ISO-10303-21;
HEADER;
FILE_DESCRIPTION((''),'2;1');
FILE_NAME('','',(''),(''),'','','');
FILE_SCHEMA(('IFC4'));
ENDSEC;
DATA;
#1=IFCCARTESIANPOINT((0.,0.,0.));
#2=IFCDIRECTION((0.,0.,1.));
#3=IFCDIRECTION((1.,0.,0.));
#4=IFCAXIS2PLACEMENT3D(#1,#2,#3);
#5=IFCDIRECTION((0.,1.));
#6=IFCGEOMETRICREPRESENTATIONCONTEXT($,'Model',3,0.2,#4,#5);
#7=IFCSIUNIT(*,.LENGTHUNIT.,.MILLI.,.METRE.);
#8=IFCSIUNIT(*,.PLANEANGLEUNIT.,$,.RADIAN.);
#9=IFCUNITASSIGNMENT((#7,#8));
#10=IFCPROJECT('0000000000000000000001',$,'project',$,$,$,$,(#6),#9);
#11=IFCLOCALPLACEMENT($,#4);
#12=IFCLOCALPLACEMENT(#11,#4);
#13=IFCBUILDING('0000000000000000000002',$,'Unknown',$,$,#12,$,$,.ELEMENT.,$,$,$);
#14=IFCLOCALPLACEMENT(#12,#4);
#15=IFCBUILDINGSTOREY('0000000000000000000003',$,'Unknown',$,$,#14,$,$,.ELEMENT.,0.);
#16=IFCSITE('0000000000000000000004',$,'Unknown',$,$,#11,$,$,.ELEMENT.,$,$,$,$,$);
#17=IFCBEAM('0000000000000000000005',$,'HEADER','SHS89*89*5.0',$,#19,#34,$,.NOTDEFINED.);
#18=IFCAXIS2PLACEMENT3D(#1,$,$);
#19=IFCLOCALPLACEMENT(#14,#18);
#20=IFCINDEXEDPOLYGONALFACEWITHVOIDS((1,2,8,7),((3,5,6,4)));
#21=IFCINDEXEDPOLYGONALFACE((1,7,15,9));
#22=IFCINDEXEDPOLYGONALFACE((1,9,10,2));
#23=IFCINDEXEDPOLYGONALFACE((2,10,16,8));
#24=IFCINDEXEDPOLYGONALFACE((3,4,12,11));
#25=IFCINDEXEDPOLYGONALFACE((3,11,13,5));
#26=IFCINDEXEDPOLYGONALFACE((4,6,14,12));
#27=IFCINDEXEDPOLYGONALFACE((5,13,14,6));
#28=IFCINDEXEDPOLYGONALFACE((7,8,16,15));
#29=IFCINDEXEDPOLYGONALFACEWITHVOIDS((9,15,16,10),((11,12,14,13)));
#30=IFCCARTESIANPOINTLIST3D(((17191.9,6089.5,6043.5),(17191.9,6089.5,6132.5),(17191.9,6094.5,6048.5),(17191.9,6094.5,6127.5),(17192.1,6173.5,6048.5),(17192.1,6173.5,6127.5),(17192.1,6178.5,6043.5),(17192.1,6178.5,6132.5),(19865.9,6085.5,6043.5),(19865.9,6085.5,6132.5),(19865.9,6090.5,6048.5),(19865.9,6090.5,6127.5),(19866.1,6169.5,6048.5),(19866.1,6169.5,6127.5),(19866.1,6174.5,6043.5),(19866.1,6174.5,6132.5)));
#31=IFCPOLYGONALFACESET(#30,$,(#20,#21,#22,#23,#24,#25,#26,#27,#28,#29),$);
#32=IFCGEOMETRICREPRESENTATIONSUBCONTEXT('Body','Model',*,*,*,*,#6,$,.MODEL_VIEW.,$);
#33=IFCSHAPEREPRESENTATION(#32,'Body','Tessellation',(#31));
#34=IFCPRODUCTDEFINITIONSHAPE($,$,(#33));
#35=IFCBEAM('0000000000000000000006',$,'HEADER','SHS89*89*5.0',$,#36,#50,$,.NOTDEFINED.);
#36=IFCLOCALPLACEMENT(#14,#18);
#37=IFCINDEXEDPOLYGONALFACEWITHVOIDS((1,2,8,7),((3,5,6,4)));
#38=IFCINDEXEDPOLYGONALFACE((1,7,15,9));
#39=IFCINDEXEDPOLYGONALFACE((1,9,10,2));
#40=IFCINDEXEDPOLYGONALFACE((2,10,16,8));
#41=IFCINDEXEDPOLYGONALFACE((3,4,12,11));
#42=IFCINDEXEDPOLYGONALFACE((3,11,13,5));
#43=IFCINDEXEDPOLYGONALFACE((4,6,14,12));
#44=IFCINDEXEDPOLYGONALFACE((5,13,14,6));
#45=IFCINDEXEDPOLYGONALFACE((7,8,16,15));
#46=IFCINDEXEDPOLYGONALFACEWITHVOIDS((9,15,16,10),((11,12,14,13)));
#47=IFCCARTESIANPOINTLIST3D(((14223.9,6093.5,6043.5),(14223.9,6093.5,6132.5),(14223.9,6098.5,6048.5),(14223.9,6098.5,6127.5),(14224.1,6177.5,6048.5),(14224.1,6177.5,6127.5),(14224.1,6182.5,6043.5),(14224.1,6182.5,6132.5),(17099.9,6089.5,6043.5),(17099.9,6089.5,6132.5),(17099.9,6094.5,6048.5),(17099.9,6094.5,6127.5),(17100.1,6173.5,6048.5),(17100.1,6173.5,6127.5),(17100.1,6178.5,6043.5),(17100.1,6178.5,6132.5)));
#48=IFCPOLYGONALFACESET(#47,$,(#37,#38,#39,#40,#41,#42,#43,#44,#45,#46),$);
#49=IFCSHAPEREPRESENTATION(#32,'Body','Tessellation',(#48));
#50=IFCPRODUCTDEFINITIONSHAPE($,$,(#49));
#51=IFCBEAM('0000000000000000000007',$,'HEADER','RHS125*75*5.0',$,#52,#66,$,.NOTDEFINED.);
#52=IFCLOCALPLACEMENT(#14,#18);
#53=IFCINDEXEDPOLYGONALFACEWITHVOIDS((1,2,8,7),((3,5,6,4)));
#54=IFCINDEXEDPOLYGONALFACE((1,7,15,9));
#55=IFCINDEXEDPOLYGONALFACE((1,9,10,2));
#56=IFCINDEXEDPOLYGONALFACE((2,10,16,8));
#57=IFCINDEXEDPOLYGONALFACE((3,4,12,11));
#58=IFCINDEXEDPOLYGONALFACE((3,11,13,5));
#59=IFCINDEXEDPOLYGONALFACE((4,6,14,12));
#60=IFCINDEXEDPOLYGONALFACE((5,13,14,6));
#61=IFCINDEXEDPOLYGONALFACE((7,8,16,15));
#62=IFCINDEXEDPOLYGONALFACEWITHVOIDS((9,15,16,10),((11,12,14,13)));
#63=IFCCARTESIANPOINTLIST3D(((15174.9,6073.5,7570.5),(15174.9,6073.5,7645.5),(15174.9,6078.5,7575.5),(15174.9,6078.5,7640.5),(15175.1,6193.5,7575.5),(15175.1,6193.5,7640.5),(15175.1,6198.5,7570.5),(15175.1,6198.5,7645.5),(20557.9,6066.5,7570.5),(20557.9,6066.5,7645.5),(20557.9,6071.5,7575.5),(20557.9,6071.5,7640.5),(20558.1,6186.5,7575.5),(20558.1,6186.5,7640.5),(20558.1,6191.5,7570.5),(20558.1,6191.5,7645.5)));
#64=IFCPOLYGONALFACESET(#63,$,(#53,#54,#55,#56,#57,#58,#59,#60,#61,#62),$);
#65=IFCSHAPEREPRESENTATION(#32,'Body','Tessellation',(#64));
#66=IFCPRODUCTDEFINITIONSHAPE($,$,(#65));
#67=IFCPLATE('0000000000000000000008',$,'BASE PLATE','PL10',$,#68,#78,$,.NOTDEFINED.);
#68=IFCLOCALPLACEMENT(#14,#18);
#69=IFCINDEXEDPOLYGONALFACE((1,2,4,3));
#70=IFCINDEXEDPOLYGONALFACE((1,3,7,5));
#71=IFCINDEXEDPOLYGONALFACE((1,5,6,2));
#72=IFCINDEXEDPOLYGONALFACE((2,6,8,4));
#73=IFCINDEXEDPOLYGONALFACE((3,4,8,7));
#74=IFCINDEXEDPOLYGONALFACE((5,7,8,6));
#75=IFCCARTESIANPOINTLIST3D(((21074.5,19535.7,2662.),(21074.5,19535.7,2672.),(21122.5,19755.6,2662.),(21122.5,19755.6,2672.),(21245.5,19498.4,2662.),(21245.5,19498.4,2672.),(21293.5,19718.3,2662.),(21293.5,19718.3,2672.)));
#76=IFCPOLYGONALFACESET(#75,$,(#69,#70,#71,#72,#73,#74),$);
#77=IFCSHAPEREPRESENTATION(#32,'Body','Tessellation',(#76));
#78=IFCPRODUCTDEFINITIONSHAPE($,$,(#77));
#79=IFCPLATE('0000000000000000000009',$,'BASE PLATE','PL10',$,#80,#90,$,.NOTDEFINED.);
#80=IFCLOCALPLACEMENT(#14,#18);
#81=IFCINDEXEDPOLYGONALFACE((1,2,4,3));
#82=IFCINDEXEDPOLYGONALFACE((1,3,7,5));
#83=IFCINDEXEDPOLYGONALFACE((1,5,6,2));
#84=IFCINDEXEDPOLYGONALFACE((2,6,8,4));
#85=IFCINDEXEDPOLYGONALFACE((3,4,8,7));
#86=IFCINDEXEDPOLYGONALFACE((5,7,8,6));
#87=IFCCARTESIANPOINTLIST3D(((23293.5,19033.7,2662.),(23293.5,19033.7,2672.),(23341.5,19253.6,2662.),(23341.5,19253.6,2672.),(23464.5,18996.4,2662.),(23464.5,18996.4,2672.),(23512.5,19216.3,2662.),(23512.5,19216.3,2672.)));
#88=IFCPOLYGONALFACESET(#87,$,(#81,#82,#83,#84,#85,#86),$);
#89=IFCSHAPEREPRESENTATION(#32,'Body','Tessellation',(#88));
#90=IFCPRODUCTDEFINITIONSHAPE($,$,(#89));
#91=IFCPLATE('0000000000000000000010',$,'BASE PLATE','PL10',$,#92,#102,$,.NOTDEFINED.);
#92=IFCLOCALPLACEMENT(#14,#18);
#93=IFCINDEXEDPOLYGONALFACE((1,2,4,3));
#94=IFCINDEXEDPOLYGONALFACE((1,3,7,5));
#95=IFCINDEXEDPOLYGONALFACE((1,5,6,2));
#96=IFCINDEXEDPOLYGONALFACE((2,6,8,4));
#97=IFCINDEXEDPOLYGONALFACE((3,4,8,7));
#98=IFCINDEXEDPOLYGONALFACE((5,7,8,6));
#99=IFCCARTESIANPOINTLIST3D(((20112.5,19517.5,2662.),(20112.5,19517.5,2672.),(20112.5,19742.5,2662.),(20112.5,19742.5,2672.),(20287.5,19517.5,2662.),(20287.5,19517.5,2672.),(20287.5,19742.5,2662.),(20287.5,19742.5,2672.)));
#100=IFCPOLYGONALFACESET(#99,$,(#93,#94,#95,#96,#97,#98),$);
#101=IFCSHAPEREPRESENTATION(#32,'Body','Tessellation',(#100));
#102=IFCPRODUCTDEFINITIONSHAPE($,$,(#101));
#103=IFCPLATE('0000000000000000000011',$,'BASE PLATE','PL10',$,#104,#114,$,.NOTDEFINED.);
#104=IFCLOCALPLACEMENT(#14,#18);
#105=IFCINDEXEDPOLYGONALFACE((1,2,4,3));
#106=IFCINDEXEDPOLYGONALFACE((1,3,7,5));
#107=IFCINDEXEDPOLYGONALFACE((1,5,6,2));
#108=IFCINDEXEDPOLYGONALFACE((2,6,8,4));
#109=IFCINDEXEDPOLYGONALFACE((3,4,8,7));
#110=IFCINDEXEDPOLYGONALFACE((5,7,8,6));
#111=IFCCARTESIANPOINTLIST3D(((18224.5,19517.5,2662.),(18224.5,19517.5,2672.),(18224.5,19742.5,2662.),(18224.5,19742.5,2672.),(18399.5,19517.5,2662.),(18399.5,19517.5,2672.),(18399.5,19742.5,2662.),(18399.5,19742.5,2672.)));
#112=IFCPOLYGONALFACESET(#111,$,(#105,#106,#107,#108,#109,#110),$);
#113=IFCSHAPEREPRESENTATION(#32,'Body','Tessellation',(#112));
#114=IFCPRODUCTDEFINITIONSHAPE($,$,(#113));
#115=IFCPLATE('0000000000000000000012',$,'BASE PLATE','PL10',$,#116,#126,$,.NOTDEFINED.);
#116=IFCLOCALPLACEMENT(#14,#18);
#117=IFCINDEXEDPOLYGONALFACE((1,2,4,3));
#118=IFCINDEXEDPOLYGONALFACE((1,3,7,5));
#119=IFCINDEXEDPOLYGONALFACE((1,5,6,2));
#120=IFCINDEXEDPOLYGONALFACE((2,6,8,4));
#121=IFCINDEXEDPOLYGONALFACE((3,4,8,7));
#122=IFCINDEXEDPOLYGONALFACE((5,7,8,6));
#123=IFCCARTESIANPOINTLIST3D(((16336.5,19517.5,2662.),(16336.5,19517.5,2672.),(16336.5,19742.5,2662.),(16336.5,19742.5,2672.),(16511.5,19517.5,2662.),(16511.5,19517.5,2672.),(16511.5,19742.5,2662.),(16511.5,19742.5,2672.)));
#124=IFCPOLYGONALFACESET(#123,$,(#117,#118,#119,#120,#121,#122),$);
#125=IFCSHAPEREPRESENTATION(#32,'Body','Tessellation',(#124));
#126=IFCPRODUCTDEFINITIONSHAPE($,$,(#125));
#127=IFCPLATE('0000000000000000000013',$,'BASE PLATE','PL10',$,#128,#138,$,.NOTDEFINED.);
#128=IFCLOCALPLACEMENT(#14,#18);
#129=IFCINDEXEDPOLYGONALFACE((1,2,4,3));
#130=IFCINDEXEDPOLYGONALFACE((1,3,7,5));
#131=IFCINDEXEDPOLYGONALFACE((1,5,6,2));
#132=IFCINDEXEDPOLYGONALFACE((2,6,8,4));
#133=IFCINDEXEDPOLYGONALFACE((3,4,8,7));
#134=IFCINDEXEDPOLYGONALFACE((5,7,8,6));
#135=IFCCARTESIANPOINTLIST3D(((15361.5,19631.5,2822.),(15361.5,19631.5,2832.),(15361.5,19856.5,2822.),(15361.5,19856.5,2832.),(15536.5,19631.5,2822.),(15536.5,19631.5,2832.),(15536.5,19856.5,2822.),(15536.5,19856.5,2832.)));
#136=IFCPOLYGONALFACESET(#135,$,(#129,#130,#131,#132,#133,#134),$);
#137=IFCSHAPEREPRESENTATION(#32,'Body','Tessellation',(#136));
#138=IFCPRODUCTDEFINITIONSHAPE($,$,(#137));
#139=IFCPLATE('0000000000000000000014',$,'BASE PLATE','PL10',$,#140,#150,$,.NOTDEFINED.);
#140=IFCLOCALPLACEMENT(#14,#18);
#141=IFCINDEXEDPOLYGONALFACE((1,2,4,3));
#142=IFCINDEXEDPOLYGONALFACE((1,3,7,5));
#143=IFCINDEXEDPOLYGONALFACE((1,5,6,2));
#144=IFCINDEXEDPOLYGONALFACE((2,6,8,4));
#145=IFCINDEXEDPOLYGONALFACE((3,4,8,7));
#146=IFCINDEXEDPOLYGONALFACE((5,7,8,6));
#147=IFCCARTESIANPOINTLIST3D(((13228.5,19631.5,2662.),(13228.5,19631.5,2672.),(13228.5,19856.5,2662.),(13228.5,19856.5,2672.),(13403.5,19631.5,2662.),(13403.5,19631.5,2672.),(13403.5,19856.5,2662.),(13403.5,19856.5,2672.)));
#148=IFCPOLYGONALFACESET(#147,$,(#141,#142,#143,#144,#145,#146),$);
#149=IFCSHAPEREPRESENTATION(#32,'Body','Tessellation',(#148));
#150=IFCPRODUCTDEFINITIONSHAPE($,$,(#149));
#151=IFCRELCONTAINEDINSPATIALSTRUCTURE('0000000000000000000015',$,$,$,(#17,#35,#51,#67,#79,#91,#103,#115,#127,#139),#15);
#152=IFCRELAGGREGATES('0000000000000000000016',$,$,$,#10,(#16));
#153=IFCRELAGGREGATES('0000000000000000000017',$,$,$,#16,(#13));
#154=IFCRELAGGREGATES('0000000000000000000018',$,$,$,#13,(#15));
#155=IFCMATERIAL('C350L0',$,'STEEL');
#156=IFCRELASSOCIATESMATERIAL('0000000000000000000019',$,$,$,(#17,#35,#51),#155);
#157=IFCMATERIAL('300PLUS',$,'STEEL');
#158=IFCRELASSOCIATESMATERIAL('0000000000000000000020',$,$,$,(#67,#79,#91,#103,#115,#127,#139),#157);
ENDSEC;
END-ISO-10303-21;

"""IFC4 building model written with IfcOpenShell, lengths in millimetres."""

from ifc_helpers import new_model, si_unit, direction, frame, origin_with_axes, place, context, subcontext, project, spatial, line, indexed_curve, outline, extrude, material, element, save


model = new_model("IFC4")

# Units and contexts
model_context = context("Model", 3, precision=0.2, world=origin_with_axes(), true_north=direction((0.0, 1.0)))
body_context = subcontext(model_context, "Body", "Model", "MODEL_VIEW")
ifc_project = project(units=[si_unit("LENGTHUNIT", "METRE", prefix="MILLI"), si_unit("PLANEANGLEUNIT", "RADIAN")], contexts=[model_context])

# Site, building, storey
site_placement = place(None, origin_with_axes())
site = spatial("IfcSite", under=ifc_project, at=site_placement, Name="Unknown", CompositionType="ELEMENT")
building_placement = place(site_placement, origin_with_axes())
building = spatial("IfcBuilding", under=site, at=building_placement, Name="Unknown", CompositionType="ELEMENT")
storey_placement = place(building_placement, origin_with_axes())
storey = spatial("IfcBuildingStorey", under=building, at=storey_placement, Name="Unknown", CompositionType="ELEMENT", Elevation=0.0)

# Shared definitions
ifc_material_1 = material(Name="C350L0", Category="STEEL")

# Beams
beam_1_placement = place(storey_placement, frame((17192.0, 6134.0, 6088.0), z_axis=(0.0, 0.0, 1.0), x_axis=(0.999999, -0.001496, 0.0)))
element("IfcBeam", 1, at=beam_1_placement, inside=storey, material=ifc_material_1, Name="HEADER", Description="SHS89*89*5.0", PredefinedType="NOTDEFINED", context=body_context, shape_type="SolidModel", body=[
    extrude(outline(indexed_curve([(-44.5, -44.5), (44.5, -44.5), (44.5, 44.5), (-44.5, 44.5)], segments=[line(1, 2, 3, 4, 1)]), holes=[indexed_curve([(-39.5, -39.5), (-39.5, 39.5), (39.5, 39.5), (39.5, -39.5)], segments=[line(1, 2, 3, 4, 1)])]), frame((0.0, 0.0, 0.0), z_axis=(-1.0, 0.0, 0.0), x_axis=(0.0, 0.0, 1.0)), (0.0, 0.0, -1.0), 2674.0),
])
beam_2_placement = place(storey_placement, frame((14224.0, 6138.0, 6088.0), z_axis=(0.0, 0.0, 1.0), x_axis=(0.999999, -0.001391, 0.0)))
element("IfcBeam", 2, at=beam_2_placement, inside=storey, material=ifc_material_1, Name="HEADER", Description="SHS89*89*5.0", PredefinedType="NOTDEFINED", context=body_context, shape_type="SolidModel", body=[
    extrude(outline(indexed_curve([(-44.5, -44.5), (44.5, -44.5), (44.5, 44.5), (-44.5, 44.5)], segments=[line(1, 2, 3, 4, 1)]), holes=[indexed_curve([(-39.5, -39.5), (-39.5, 39.5), (39.5, 39.5), (39.5, -39.5)], segments=[line(1, 2, 3, 4, 1)])]), frame((0.0, 0.0, 0.0), z_axis=(-1.0, 0.0, 0.0), x_axis=(0.0, 0.0, 1.0)), (0.0, 0.0, -1.0), 2876.0),
])
beam_3_placement = place(storey_placement, frame((15175.0, 6136.0, 7608.0), z_axis=(0.0, 0.0, 1.0), x_axis=(0.999999, -0.0013, 0.0)))
element("IfcBeam", 3, at=beam_3_placement, inside=storey, material=ifc_material_1, Name="HEADER", Description="RHS125*75*5.0", PredefinedType="NOTDEFINED", context=body_context, shape_type="SolidModel", body=[
    extrude(outline(indexed_curve([(-37.5, -62.5), (37.5, -62.5), (37.5, 62.5), (-37.5, 62.5)], segments=[line(1, 2, 3, 4, 1)]), holes=[indexed_curve([(-32.5, -57.5), (-32.5, 57.5), (32.5, 57.5), (32.5, -57.5)], segments=[line(1, 2, 3, 4, 1)])]), frame((0.0, 0.0, 0.0), z_axis=(-1.0, 0.0, 0.0), x_axis=(0.0, 0.0, 1.0)), (0.0, 0.0, -1.0), 5383.0),
])

# Plates
ifc_material_2 = material(Name="300PLUS", Category="STEEL")
for number, where, z_axis, x_axis, name in (
    (4, (21245.5, 19498.4, 2667.0), (0.0, 0.0, 1.0), (0.21326, 0.976996, 0.0), "BASE PLATE"),
    (5, (23464.5, 18996.4, 2667.0), (0.0, 0.0, 1.0), (0.21326, 0.976996, 0.0), "BASE PLATE"),
):
    element("IfcPlate", number, at=place(storey_placement, frame(where, z_axis=z_axis, x_axis=x_axis)), inside=storey, material=ifc_material_2, Name=name, Description="PL10", PredefinedType="NOTDEFINED", context=body_context, shape_type="SolidModel", body=[
        extrude(outline(indexed_curve([(0.0, 0.0), (225.1, 0.0), (225.1, 175.0), (0.0, 175.0)], segments=[line(1, 2, 3, 4, 1)])), frame((0.0, 0.0, 5.0), z_axis=(0.0, 0.0, 1.0), x_axis=(1.0, 0.0, 0.0)), (0.0, 0.0, -1.0), 10.0),
    ])
for number, where, z_axis, x_axis, name in (
    (6, (20287.5, 19517.5, 2667.0), (0.0, 0.0, 1.0), (0.0, 1.0, 0.0), "BASE PLATE"),
    (7, (18399.5, 19517.5, 2667.0), (0.0, 0.0, 1.0), (0.0, 1.0, 0.0), "BASE PLATE"),
    (8, (16511.5, 19517.5, 2667.0), (0.0, 0.0, 1.0), (0.0, 1.0, 0.0), "BASE PLATE"),
    (9, (15536.5, 19631.5, 2827.0), (0.0, 0.0, 1.0), (0.0, 1.0, 0.0), "BASE PLATE"),
    (10, (13403.5, 19631.5, 2667.0), (0.0, 0.0, 1.0), (0.0, 1.0, 0.0), "BASE PLATE"),
):
    element("IfcPlate", number, at=place(storey_placement, frame(where, z_axis=z_axis, x_axis=x_axis)), inside=storey, material=ifc_material_2, Name=name, Description="PL10", PredefinedType="NOTDEFINED", context=body_context, shape_type="SolidModel", body=[
        extrude(outline(indexed_curve([(0.0, 0.0), (225.0, 0.0), (225.0, 175.0), (0.0, 175.0)], segments=[line(1, 2, 3, 4, 1)])), frame((0.0, 0.0, 5.0), z_axis=(0.0, 0.0, 1.0), x_axis=(1.0, 0.0, 0.0)), (0.0, 0.0, -1.0), 10.0),
    ])

save(model, "model.ifc")
